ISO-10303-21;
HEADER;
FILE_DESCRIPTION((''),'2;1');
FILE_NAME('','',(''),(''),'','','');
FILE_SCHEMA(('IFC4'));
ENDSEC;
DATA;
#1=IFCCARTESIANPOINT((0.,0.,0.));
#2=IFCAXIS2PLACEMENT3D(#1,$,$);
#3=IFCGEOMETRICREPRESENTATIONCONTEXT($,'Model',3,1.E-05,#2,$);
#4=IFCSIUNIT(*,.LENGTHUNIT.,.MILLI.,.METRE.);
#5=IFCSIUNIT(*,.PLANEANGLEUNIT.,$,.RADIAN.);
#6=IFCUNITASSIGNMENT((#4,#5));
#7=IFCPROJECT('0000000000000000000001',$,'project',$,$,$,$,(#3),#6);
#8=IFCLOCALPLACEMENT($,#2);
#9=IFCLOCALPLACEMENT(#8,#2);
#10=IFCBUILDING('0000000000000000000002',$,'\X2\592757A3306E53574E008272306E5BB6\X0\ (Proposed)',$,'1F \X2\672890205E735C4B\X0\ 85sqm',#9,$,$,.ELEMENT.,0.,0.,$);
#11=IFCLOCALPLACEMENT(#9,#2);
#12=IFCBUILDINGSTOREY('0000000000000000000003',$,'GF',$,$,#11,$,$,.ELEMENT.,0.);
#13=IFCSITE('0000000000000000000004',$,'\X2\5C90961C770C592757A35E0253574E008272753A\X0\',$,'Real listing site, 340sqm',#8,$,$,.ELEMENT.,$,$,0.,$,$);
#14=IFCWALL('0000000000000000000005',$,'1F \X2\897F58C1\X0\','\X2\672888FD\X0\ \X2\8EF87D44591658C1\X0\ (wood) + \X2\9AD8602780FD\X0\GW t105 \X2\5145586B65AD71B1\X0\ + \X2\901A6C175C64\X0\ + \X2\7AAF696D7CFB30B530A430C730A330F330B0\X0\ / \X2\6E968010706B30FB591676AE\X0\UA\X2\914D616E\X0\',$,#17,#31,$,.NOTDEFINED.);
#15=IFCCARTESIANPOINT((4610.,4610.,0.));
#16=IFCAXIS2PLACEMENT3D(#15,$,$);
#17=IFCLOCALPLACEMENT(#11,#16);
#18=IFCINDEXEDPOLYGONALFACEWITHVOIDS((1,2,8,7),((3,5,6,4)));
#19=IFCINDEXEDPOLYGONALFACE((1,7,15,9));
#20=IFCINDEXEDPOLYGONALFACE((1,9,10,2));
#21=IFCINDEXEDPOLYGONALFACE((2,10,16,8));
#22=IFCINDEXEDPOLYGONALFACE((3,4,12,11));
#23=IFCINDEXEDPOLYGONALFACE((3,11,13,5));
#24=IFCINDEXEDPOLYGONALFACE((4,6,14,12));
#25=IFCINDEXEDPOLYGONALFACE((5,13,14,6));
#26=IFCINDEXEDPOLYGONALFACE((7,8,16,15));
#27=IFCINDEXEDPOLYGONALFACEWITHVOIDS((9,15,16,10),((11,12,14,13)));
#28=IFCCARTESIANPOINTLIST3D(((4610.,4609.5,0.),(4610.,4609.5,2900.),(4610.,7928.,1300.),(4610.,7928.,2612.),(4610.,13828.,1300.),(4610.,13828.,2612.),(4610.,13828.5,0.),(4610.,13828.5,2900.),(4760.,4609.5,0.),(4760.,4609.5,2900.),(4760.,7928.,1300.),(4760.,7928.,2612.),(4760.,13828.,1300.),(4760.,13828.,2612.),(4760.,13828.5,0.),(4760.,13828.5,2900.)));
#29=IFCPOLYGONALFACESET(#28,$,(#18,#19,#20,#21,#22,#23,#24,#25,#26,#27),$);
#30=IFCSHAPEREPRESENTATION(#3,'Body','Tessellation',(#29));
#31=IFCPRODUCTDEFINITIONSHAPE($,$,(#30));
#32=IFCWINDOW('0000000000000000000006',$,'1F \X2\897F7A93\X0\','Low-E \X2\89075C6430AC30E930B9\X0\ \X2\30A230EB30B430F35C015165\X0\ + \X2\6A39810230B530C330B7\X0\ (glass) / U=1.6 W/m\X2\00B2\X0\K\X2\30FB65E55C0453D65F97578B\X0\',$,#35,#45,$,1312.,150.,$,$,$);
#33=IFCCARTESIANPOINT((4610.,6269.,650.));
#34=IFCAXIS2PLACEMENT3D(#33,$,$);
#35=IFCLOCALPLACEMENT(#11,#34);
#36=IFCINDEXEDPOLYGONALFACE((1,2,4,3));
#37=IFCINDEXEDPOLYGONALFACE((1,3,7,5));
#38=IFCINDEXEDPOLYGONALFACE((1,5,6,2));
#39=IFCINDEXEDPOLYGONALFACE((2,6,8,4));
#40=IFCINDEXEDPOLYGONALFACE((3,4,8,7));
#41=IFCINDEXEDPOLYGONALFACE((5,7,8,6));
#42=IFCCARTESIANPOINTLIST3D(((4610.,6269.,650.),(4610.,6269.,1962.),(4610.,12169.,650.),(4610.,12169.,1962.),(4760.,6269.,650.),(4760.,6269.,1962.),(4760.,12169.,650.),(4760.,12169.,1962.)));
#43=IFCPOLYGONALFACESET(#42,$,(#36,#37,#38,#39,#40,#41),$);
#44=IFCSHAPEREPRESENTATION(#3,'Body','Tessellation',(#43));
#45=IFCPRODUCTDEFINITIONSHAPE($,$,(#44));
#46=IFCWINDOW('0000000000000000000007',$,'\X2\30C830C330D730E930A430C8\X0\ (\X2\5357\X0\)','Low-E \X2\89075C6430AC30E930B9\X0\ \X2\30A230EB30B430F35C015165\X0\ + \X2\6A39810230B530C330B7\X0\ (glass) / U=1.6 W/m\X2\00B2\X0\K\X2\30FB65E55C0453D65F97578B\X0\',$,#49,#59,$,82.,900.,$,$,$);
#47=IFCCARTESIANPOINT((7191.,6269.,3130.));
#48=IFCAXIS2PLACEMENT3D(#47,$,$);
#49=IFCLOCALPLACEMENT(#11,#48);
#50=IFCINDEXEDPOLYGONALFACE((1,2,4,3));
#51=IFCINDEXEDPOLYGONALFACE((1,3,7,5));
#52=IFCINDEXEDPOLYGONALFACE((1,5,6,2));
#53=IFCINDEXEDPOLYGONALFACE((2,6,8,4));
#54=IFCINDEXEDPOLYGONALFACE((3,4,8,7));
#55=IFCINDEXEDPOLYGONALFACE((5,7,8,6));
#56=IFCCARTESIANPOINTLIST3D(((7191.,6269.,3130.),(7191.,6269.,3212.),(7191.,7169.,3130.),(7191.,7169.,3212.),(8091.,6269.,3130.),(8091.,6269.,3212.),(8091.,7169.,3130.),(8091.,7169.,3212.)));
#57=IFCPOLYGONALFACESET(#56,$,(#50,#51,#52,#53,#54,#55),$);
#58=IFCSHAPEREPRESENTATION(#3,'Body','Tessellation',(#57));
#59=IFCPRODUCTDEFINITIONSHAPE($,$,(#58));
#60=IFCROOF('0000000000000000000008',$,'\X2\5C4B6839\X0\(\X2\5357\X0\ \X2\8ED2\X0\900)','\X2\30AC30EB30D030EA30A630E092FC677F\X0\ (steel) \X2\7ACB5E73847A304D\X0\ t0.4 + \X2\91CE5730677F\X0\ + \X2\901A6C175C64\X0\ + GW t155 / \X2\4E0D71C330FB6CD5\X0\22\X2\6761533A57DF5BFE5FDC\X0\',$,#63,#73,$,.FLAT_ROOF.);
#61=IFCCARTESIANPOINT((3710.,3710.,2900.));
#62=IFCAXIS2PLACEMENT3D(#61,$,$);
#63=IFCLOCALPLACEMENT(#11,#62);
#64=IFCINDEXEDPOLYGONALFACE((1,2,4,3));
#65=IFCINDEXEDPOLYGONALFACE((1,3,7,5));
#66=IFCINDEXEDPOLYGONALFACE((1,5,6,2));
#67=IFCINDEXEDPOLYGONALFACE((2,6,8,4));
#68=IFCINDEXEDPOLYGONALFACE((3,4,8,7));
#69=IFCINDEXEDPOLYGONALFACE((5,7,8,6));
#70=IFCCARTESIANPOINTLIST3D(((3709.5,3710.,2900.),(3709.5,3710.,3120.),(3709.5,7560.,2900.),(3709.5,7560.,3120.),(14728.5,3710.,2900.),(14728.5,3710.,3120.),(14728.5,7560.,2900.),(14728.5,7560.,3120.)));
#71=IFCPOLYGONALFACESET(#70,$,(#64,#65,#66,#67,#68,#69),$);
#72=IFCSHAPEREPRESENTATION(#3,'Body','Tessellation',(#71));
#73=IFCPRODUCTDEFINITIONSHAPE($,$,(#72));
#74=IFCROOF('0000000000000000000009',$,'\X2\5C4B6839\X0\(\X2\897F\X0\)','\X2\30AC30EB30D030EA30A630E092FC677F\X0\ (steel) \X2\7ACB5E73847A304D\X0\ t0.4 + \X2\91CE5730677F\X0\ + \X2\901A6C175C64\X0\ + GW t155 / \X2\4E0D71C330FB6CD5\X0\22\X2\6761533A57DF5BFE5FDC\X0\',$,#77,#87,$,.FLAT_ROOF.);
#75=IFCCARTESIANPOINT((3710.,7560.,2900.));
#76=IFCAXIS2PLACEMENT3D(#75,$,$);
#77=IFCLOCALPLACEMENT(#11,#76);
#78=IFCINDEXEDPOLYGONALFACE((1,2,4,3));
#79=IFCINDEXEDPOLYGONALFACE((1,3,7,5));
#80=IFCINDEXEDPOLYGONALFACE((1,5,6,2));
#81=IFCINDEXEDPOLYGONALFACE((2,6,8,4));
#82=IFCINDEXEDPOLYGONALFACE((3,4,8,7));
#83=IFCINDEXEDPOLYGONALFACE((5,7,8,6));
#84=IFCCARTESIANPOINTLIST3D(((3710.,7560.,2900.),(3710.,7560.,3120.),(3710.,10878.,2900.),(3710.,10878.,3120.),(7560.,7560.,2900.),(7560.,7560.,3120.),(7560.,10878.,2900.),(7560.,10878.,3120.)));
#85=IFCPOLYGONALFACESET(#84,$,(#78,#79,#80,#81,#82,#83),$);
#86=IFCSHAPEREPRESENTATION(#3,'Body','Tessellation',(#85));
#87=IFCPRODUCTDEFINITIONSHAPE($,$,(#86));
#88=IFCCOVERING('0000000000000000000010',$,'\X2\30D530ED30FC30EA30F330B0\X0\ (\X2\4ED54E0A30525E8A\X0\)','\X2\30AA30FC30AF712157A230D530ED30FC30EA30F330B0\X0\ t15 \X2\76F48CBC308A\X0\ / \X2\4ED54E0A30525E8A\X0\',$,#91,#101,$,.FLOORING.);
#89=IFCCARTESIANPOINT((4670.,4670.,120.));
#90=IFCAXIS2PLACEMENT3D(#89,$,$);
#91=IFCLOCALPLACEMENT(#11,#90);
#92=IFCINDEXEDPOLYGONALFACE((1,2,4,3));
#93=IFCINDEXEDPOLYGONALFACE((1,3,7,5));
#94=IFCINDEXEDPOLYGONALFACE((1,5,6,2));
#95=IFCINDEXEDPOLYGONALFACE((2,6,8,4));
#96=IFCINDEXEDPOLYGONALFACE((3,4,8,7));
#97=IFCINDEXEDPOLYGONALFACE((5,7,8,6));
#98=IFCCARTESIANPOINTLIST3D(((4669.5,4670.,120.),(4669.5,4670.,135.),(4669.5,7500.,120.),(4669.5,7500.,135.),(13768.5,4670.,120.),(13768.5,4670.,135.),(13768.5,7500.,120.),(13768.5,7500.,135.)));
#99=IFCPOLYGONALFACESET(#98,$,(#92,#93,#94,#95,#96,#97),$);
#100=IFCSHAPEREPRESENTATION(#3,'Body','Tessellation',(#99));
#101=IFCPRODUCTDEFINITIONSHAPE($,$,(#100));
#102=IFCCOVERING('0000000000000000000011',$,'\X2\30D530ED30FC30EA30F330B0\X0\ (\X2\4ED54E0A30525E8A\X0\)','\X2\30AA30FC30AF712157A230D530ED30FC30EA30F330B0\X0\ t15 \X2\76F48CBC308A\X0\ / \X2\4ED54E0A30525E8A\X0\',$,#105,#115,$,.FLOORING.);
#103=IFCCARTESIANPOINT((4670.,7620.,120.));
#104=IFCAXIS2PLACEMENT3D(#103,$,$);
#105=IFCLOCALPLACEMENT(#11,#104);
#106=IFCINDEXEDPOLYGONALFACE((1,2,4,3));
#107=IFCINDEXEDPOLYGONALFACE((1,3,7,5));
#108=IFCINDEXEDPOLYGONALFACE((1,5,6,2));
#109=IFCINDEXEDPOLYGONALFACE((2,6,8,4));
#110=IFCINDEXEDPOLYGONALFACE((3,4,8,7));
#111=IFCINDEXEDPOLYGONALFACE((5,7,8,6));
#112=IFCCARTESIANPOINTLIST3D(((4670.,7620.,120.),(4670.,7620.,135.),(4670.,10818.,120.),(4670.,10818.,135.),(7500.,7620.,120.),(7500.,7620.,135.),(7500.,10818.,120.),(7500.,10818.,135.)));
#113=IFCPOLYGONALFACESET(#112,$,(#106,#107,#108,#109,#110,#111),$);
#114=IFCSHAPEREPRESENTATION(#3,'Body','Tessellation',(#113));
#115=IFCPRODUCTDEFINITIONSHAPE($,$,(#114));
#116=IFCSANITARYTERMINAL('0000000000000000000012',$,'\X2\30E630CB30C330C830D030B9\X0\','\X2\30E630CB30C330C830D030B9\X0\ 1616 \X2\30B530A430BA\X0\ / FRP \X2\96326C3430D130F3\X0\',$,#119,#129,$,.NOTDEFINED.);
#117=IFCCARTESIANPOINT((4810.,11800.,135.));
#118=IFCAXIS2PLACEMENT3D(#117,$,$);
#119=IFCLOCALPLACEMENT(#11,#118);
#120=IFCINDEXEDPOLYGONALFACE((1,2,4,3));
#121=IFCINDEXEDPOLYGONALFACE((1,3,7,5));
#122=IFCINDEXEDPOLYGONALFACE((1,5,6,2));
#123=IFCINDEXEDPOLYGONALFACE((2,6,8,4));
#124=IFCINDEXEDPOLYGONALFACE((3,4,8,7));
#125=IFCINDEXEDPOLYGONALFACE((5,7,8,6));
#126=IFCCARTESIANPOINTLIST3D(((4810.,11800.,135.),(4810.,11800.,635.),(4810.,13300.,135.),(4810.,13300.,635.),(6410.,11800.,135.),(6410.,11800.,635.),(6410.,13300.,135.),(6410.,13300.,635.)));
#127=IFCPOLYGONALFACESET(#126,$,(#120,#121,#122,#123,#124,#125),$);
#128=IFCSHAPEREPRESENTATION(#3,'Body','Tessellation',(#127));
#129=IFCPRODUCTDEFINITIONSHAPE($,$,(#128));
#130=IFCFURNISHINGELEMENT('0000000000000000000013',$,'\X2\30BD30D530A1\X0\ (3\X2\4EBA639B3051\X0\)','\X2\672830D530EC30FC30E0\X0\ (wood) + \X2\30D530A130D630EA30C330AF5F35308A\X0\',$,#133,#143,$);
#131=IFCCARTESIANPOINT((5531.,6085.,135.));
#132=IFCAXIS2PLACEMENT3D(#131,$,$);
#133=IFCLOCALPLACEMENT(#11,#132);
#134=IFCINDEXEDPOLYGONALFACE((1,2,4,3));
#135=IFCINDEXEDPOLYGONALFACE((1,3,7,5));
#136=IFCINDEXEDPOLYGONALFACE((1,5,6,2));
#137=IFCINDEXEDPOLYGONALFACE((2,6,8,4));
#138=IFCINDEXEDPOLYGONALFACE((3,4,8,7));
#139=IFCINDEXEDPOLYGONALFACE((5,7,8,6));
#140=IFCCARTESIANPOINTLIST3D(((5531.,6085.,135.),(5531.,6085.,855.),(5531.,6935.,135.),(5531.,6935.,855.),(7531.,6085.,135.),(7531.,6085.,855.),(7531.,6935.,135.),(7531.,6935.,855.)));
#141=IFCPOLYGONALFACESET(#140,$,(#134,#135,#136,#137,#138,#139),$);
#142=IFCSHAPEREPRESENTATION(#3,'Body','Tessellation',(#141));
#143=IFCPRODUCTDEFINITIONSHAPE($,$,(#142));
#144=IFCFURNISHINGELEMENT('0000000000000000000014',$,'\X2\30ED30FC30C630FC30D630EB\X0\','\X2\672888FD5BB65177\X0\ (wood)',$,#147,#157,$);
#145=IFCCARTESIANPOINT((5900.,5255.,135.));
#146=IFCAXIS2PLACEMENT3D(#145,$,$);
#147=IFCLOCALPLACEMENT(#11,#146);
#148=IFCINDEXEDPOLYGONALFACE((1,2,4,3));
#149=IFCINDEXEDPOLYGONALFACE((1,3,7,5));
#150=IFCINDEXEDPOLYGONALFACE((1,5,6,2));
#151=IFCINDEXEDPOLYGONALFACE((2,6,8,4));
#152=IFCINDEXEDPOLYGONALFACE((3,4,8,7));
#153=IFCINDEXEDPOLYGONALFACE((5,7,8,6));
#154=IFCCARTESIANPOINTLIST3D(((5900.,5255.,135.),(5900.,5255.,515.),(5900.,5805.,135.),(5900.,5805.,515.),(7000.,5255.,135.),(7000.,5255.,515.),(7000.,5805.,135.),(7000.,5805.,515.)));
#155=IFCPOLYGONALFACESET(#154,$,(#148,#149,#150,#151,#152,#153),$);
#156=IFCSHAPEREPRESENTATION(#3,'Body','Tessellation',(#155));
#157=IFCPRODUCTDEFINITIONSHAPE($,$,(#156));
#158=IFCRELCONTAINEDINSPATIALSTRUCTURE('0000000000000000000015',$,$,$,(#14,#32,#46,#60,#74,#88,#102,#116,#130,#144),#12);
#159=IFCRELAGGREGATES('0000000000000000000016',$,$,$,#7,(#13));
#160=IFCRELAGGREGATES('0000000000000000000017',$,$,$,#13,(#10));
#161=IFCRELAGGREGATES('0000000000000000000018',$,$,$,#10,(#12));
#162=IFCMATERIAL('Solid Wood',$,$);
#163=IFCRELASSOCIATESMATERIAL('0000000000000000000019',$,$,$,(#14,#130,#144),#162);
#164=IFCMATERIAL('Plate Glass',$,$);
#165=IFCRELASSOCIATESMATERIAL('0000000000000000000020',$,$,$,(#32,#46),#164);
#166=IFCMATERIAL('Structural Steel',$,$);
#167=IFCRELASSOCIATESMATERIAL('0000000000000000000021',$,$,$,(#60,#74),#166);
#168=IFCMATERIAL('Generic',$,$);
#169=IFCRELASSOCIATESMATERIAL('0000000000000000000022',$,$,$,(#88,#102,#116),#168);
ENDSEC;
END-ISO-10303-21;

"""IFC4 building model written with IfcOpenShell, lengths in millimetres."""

from ifc_helpers import new_model, si_unit, frame, frame_2d, origin, place, context, project, spatial, rectangle, extrude, material, element, fill, save


model = new_model("IFC4")

# Units and contexts
model_context = context("Model", 3, precision=1e-05, world=origin())
ifc_project = project(units=[si_unit("LENGTHUNIT", "METRE", prefix="MILLI"), si_unit("PLANEANGLEUNIT", "RADIAN")], contexts=[model_context])

# Site, building, storey
site_placement = place(None, origin())
site = spatial("IfcSite", under=ifc_project, at=site_placement, Name="岐阜県大垣市南一色町", ObjectType="Real listing site, 340sqm", CompositionType="ELEMENT", RefElevation=0.0)
building_placement = place(site_placement, origin())
building = spatial("IfcBuilding", under=site, at=building_placement, Name="大垣の南一色の家 (Proposed)", ObjectType="1F 木造平屋 85sqm", CompositionType="ELEMENT", ElevationOfRefHeight=0.0, ElevationOfTerrain=0.0)
storey_placement = place(building_placement, origin())
storey = spatial("IfcBuildingStorey", under=building, at=storey_placement, Name="GF", CompositionType="ELEMENT", Elevation=0.0)

# Shared definitions
ifc_material_1 = material(Name="Solid Wood")

# Shared definitions
ifc_material_2 = material(Name="Plate Glass")

# Wall, opening, window
wall_1_placement = place(storey_placement, frame((4610.0, 4610.0, 0.0)))
wall_1 = element("IfcWall", 1, at=wall_1_placement, inside=storey, material=ifc_material_1, Name="1F 西壁", Description="木製 軸組外壁 (wood) + 高性能GW t105 充填断熱 + 通気層 + 窯業系サイディング / 準耐火・外皮UA配慮", PredefinedType="NOTDEFINED", context=model_context, shape_type="SweptSolid", body=[
    extrude(rectangle(XDim=150.0, YDim=9219.0, at=frame_2d((75.0, 4609.0))), frame((4610.0, 4610.0, 0.0)), (0.0, 0.0, 1.0), 2900.0),
])
opening_1_placement = place(storey_placement, frame((4610.0, 6269.0, 650.0)))
opening_1 = element("IfcOpeningElement", 2, at=opening_1_placement, cuts=wall_1, PredefinedType="NOTDEFINED", context=model_context, shape_type="SweptSolid", body=[
    extrude(rectangle(XDim=150.0, YDim=5900.0, at=frame_2d((75.0, 2950.0))), frame((4610.0, 6269.0, 650.0)), (0.0, 0.0, 1.0), 1312.0),
])
window_1_placement = place(storey_placement, frame((4610.0, 6269.0, 650.0)))
window_1 = element("IfcWindow", 3, at=window_1_placement, inside=storey, material=ifc_material_2, Name="1F 西窓", Description="Low-E 複層ガラス アルゴン封入 + 樹脂サッシ (glass) / U=1.6 W/m²K・日射取得型", OverallHeight=1312.0, OverallWidth=150.0, context=model_context, shape_type="SweptSolid", body=[
    extrude(rectangle(XDim=150.0, YDim=5900.0, at=frame_2d((75.0, 2950.0))), frame((4610.0, 6269.0, 650.0)), (0.0, 0.0, 1.0), 1312.0),
])
fill(opening_1, window_1)

# Window
window_2_placement = place(storey_placement, frame((7191.0, 6269.0, 3130.0)))
element("IfcWindow", 4, at=window_2_placement, inside=storey, material=ifc_material_2, Name="トップライト (南)", Description="Low-E 複層ガラス アルゴン封入 + 樹脂サッシ (glass) / U=1.6 W/m²K・日射取得型", OverallHeight=82.0, OverallWidth=900.0, context=model_context, shape_type="SweptSolid", body=[
    extrude(rectangle(XDim=900.0, YDim=900.0, at=frame_2d((450.0, 450.0))), frame((7191.0, 6269.0, 3130.0)), (0.0, 0.0, 1.0), 82.0),
])

# Roofs
ifc_material_3 = material(Name="Structural Steel")
roof_1_placement = place(storey_placement, frame((3710.0, 3710.0, 2900.0)))
element("IfcRoof", 5, at=roof_1_placement, inside=storey, material=ifc_material_3, Name="屋根(南 軒900)", Description="ガルバリウム鋼板 (steel) 立平葺き t0.4 + 野地板 + 通気層 + GW t155 / 不燃・法22条区域対応", PredefinedType="FLAT_ROOF", context=model_context, shape_type="SweptSolid", body=[
    extrude(rectangle(XDim=11019.0, YDim=3850.0, at=frame_2d((5509.0, 1925.0))), frame((3710.0, 3710.0, 2900.0)), (0.0, 0.0, 1.0), 220.0),
])
roof_2_placement = place(storey_placement, frame((3710.0, 7560.0, 2900.0)))
element("IfcRoof", 6, at=roof_2_placement, inside=storey, material=ifc_material_3, Name="屋根(西)", Description="ガルバリウム鋼板 (steel) 立平葺き t0.4 + 野地板 + 通気層 + GW t155 / 不燃・法22条区域対応", PredefinedType="FLAT_ROOF", context=model_context, shape_type="SweptSolid", body=[
    extrude(rectangle(XDim=3850.0, YDim=3318.0, at=frame_2d((1925.0, 1659.0))), frame((3710.0, 7560.0, 2900.0)), (0.0, 0.0, 1.0), 220.0),
])

# Coverings
ifc_material_4 = material(Name="Generic")
covering_1_placement = place(storey_placement, frame((4670.0, 4670.0, 120.0)))
element("IfcCovering", 7, at=covering_1_placement, inside=storey, material=ifc_material_4, Name="フローリング (仕上げ床)", Description="オーク無垢フローリング t15 直貼り / 仕上げ床", PredefinedType="FLOORING", context=model_context, shape_type="SweptSolid", body=[
    extrude(rectangle(XDim=9099.0, YDim=2830.0, at=frame_2d((4549.0, 1415.0))), frame((4670.0, 4670.0, 120.0)), (0.0, 0.0, 1.0), 15.0),
])
covering_2_placement = place(storey_placement, frame((4670.0, 7620.0, 120.0)))
element("IfcCovering", 8, at=covering_2_placement, inside=storey, material=ifc_material_4, Name="フローリング (仕上げ床)", Description="オーク無垢フローリング t15 直貼り / 仕上げ床", PredefinedType="FLOORING", context=model_context, shape_type="SweptSolid", body=[
    extrude(rectangle(XDim=2830.0, YDim=3198.0, at=frame_2d((1415.0, 1599.0))), frame((4670.0, 7620.0, 120.0)), (0.0, 0.0, 1.0), 15.0),
])

# Sanitary terminal
sanitary_terminal_placement = place(storey_placement, frame((4810.0, 11800.0, 135.0)))
element("IfcSanitaryTerminal", 9, at=sanitary_terminal_placement, inside=storey, material=ifc_material_4, Name="ユニットバス", Description="ユニットバス 1616 サイズ / FRP 防水パン", PredefinedType="NOTDEFINED", context=model_context, shape_type="SweptSolid", body=[
    extrude(rectangle(XDim=1600.0, YDim=1500.0, at=frame_2d((800.0, 750.0))), frame((4810.0, 11800.0, 135.0)), (0.0, 0.0, 1.0), 500.0),
])

# Furnishing elements
furnishing_1_placement = place(storey_placement, frame((5531.0, 6085.0, 135.0)))
element("IfcFurnishingElement", 10, at=furnishing_1_placement, inside=storey, material=ifc_material_1, Name="ソファ (3人掛け)", Description="木フレーム (wood) + ファブリック張り", context=model_context, shape_type="SweptSolid", body=[
    extrude(rectangle(XDim=2000.0, YDim=850.0, at=frame_2d((1000.0, 425.0))), frame((5531.0, 6085.0, 135.0)), (0.0, 0.0, 1.0), 720.0),
])
furnishing_2_placement = place(storey_placement, frame((5900.0, 5255.0, 135.0)))
element("IfcFurnishingElement", 11, at=furnishing_2_placement, inside=storey, material=ifc_material_1, Name="ローテーブル", Description="木製家具 (wood)", context=model_context, shape_type="SweptSolid", body=[
    extrude(rectangle(XDim=1100.0, YDim=550.0, at=frame_2d((550.0, 275.0))), frame((5900.0, 5255.0, 135.0)), (0.0, 0.0, 1.0), 380.0),
])

save(model, "model.ifc")
